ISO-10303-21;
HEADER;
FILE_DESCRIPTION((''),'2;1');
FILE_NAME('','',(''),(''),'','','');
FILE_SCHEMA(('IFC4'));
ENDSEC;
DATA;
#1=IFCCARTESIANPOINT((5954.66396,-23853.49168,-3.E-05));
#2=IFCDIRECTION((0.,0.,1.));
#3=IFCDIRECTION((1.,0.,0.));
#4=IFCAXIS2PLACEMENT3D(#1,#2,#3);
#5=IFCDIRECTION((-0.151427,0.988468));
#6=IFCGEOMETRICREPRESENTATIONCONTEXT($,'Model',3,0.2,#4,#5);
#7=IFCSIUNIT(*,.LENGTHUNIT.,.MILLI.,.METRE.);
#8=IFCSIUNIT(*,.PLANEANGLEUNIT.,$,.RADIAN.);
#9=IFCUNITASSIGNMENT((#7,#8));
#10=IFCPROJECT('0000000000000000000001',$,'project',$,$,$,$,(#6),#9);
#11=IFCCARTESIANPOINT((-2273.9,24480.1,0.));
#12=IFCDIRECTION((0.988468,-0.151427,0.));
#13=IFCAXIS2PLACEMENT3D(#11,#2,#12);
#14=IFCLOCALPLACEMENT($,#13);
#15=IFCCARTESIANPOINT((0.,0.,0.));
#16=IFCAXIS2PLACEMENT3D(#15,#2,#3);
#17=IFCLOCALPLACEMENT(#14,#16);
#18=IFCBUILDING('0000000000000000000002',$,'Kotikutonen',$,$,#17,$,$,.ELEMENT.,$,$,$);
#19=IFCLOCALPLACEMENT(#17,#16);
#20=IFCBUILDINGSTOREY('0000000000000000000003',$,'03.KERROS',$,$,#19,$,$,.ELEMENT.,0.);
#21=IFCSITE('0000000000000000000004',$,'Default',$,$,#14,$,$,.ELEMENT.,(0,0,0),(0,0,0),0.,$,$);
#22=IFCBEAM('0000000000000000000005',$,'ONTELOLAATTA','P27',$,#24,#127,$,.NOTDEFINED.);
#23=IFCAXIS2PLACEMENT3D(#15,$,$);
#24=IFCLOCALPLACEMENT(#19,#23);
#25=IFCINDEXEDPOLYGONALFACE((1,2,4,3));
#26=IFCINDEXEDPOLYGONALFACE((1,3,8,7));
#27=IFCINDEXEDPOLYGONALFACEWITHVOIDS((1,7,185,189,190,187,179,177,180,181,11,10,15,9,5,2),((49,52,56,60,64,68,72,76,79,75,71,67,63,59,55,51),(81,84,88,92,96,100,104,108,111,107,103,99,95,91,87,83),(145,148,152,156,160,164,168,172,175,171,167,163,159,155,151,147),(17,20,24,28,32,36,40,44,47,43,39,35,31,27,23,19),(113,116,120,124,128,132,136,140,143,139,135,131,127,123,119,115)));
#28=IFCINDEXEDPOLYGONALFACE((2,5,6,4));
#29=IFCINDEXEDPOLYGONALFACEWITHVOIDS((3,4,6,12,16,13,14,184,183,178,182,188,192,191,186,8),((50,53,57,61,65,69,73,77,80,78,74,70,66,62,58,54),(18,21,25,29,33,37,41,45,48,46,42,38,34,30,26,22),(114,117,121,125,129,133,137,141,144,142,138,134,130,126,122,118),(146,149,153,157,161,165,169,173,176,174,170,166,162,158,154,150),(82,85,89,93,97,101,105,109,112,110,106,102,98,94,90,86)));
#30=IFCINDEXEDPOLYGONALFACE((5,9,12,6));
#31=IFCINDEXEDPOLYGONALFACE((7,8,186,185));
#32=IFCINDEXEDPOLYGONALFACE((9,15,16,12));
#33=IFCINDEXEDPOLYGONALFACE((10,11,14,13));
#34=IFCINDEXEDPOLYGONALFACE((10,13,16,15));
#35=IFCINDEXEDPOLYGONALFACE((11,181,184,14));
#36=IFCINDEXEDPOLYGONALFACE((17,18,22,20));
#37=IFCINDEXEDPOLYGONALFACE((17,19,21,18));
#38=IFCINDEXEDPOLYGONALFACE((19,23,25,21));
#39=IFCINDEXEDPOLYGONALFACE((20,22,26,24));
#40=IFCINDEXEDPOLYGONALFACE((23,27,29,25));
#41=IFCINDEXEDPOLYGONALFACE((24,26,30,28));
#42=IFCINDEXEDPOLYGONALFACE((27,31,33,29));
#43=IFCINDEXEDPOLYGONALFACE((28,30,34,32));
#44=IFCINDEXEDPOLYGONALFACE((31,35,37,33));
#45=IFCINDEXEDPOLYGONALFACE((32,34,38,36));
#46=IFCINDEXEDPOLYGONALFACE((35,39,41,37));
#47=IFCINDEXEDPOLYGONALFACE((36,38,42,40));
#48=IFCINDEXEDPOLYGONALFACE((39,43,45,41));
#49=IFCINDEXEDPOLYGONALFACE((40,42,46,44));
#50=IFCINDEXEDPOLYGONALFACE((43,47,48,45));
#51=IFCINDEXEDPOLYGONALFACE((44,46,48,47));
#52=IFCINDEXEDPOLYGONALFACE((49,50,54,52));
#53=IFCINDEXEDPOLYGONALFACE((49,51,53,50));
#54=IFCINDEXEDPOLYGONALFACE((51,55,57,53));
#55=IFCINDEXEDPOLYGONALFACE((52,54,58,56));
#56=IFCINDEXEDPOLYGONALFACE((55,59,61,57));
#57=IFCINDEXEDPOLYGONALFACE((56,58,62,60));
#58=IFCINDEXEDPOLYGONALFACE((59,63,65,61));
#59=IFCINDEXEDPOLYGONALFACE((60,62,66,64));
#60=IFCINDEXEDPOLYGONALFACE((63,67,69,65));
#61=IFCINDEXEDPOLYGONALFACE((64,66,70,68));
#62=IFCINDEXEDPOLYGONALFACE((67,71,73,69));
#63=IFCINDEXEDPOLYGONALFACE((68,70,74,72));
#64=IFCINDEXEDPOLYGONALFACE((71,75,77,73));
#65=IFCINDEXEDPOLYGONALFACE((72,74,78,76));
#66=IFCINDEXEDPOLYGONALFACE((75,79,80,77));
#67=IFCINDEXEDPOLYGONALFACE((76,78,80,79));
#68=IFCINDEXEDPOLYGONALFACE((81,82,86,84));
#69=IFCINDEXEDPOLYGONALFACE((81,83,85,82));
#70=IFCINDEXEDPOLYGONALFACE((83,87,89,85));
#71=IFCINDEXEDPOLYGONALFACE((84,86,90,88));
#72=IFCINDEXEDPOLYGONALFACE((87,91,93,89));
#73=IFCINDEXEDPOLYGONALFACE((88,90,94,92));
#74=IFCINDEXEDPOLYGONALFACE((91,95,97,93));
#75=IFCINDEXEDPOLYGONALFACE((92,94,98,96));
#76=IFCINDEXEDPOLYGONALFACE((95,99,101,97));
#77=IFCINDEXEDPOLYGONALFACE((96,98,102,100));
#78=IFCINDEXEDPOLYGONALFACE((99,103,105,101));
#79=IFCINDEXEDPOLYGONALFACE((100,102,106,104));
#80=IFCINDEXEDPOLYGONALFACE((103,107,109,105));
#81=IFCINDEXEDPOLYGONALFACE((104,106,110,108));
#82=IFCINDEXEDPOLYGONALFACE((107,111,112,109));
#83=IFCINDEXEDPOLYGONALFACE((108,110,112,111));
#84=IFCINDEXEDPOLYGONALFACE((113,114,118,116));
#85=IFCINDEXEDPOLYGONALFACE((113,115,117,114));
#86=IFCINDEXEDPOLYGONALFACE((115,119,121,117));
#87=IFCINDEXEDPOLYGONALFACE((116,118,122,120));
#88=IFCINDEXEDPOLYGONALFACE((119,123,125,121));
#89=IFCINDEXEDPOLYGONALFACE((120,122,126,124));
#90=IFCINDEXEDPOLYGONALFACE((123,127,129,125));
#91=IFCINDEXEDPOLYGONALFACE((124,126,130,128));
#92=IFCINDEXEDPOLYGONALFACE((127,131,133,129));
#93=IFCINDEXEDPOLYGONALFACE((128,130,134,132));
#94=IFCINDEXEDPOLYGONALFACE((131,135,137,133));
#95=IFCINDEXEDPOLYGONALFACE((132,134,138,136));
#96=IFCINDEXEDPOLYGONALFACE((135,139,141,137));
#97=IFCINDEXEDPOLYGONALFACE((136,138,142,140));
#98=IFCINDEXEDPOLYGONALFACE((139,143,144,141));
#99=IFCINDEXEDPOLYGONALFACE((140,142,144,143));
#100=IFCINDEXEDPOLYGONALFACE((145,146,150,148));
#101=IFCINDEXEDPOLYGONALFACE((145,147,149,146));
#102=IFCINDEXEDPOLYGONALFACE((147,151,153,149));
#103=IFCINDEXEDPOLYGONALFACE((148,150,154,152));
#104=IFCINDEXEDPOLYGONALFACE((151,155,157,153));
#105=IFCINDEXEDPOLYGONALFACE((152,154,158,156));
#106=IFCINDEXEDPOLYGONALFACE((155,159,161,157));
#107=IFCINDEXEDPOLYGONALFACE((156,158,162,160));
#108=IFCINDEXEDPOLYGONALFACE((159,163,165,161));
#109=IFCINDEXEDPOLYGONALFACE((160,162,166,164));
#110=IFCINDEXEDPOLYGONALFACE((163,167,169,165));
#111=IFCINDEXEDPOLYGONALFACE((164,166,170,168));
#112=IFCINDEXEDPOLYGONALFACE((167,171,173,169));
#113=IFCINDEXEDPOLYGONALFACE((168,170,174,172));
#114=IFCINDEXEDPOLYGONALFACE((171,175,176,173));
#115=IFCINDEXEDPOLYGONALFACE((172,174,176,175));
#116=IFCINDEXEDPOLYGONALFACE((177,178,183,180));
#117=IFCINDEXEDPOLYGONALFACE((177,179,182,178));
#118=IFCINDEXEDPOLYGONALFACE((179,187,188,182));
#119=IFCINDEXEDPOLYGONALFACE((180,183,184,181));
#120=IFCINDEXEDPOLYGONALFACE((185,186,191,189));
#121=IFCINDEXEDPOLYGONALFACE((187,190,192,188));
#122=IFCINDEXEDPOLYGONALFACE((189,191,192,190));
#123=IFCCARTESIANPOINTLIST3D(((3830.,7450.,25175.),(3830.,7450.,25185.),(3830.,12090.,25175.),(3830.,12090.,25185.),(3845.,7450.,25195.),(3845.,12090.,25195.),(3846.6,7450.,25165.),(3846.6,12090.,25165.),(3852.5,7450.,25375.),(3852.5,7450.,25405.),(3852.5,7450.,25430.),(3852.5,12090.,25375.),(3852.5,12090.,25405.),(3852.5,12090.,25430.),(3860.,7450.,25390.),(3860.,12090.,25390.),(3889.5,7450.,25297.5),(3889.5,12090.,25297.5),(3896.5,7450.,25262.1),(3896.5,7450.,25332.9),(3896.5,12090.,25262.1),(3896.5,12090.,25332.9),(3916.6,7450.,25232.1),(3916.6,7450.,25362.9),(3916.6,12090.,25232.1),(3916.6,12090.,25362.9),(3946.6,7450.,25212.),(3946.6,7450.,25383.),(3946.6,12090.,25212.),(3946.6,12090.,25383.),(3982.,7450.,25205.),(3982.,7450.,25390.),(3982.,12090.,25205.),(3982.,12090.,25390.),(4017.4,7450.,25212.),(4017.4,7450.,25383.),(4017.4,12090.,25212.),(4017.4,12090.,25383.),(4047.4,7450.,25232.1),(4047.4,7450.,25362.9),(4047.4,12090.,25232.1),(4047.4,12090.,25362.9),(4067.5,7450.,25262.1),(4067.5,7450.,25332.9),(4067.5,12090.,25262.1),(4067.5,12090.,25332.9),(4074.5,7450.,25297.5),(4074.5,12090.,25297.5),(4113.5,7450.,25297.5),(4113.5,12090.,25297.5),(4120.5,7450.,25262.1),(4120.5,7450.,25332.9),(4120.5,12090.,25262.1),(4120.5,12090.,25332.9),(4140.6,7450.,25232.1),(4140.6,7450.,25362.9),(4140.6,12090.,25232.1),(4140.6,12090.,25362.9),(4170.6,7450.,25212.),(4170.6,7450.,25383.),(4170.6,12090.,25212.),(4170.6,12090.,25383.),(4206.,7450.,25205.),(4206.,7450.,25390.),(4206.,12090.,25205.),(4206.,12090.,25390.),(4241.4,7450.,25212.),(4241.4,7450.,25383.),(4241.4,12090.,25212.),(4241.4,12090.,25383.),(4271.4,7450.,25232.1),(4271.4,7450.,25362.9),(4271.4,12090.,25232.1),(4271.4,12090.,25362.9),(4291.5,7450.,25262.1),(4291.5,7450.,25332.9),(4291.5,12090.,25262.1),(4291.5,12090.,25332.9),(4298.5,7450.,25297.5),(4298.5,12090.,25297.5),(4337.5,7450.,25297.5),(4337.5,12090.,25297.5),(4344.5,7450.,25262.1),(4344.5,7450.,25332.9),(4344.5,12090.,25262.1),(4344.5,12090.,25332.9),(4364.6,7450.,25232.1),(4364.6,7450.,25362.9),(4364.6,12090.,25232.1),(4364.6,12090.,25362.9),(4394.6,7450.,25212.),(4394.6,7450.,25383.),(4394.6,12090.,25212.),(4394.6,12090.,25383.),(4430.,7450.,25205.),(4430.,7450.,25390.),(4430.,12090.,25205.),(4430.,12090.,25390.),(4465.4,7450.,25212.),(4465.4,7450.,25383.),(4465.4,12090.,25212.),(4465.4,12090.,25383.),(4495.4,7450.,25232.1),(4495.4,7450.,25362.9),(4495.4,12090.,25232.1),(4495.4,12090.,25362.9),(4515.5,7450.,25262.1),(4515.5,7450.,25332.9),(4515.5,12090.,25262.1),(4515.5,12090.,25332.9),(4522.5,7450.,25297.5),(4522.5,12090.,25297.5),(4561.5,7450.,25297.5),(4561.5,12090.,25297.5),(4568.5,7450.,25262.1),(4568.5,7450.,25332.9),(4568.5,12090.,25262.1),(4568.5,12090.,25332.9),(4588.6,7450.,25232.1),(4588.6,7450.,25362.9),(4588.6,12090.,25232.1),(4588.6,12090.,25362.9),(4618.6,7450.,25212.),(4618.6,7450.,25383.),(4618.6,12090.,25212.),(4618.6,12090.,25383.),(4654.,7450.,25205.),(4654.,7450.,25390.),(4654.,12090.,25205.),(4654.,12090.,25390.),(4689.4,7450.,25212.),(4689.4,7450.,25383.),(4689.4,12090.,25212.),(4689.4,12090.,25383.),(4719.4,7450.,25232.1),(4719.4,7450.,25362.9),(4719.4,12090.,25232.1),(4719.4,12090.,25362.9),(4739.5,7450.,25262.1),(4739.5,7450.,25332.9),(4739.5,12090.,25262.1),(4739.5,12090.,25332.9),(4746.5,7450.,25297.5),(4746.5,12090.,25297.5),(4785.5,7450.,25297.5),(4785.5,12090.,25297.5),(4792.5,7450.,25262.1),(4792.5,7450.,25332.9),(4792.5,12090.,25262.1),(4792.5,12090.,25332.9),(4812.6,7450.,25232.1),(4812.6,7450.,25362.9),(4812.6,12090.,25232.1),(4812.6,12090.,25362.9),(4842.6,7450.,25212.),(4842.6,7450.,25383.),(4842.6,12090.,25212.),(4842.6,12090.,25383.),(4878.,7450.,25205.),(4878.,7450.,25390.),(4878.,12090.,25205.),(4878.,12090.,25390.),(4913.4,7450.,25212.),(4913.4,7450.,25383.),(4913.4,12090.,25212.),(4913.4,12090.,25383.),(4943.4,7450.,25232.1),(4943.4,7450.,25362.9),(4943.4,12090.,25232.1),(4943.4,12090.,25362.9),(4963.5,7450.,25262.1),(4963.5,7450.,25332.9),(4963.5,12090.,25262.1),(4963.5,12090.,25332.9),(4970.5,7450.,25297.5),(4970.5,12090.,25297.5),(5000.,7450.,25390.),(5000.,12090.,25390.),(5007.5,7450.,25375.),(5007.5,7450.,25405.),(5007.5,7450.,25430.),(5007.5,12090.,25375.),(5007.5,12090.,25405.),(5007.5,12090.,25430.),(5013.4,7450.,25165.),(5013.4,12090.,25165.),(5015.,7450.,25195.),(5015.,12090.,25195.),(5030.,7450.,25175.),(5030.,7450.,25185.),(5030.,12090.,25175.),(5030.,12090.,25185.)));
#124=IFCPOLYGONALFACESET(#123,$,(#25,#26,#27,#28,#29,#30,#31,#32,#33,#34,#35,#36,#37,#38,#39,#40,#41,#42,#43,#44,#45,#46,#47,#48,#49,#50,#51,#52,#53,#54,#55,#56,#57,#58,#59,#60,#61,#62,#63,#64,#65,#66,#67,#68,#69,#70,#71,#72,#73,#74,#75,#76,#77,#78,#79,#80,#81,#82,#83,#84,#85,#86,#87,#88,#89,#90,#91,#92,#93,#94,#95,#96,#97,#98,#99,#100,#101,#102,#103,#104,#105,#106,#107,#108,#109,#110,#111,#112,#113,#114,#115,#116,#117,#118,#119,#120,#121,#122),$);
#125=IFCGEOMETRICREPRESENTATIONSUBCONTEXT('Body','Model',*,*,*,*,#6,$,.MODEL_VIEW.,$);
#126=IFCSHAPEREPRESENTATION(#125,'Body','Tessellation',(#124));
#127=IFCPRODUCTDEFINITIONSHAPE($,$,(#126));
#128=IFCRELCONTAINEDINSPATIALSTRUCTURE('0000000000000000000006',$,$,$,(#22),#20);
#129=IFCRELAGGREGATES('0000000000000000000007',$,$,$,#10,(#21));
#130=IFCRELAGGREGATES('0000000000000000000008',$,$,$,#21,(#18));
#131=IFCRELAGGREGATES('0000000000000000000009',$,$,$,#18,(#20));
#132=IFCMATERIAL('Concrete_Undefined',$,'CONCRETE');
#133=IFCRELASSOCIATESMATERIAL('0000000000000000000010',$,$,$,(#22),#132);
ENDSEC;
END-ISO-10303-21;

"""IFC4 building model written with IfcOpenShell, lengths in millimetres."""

from ifc_helpers import new_model, si_unit, direction, frame, origin_with_axes, place, context, subcontext, project, spatial, line, indexed_curve, outline, extrude, material, element, save


model = new_model("IFC4")

# Units and contexts
model_context = context("Model", 3, precision=0.2, world=frame((5954.66396, -23853.49168, -3e-05), z_axis=(0.0, 0.0, 1.0), x_axis=(1.0, 0.0, 0.0)), true_north=direction((-0.151427, 0.988468)))
body_context = subcontext(model_context, "Body", "Model", "MODEL_VIEW")
ifc_project = project(units=[si_unit("LENGTHUNIT", "METRE", prefix="MILLI"), si_unit("PLANEANGLEUNIT", "RADIAN")], contexts=[model_context])

# Site, building, storey
site_placement = place(None, frame((-2273.9, 24480.1, 0.0), z_axis=(0.0, 0.0, 1.0), x_axis=(0.988468, -0.151427, 0.0)))
site = spatial("IfcSite", under=ifc_project, at=site_placement, Name="Default", CompositionType="ELEMENT", RefLatitude=(0, 0, 0), RefLongitude=(0, 0, 0), RefElevation=0.0)
building_placement = place(site_placement, origin_with_axes())
building = spatial("IfcBuilding", under=site, at=building_placement, Name="Kotikutonen", CompositionType="ELEMENT")
storey_placement = place(building_placement, origin_with_axes())
storey = spatial("IfcBuildingStorey", under=building, at=storey_placement, Name="03.KERROS", CompositionType="ELEMENT", Elevation=0.0)

# Shared definitions
ifc_material_1 = material(Name="Concrete_Undefined", Category="CONCRETE")

# Beam
beam_1_placement = place(storey_placement, frame((4430.0, 12090.0, 25297.5), z_axis=(-1.0, 0.0, 0.0), x_axis=(0.0, -1.0, 0.0)))
element("IfcBeam", 1, at=beam_1_placement, inside=storey, material=ifc_material_1, Name="ONTELOLAATTA", Description="P27", PredefinedType="NOTDEFINED", context=body_context, shape_type="SolidModel", body=[
    extrude(outline(indexed_curve([(-600.0, -122.5), (-583.4, -132.5), (583.4, -132.5), (600.0, -122.5), (600.0, -112.5), (585.0, -102.5), (577.5, 77.5), (570.0, 92.5), (577.5, 107.5), (577.5, 132.5), (-577.5, 132.5), (-577.5, 107.5), (-570.0, 92.5), (-577.5, 77.5), (-585.0, -102.5), (-600.0, -112.5)], segments=[line(1, 2, 3, 4, 5, 6, 7, 8, 9, 10, 11, 12, 13, 14, 15, 16, 1)]), holes=[indexed_curve([(-448.0, -92.5), (-483.4, -85.5), (-513.4, -65.4), (-533.5, -35.4), (-540.5, 0.0), (-533.5, 35.4), (-513.4, 65.4), (-483.4, 85.5), (-448.0, 92.5), (-412.6, 85.5), (-382.6, 65.4), (-362.5, 35.4), (-355.5, 0.0), (-362.5, -35.4), (-382.6, -65.4), (-412.6, -85.5)], segments=[line(1, 2, 3, 4, 5, 6, 7, 8, 9, 10, 11, 12, 13, 14, 15, 16, 1)]), indexed_curve([(-224.0, -92.5), (-259.4, -85.5), (-289.4, -65.4), (-309.5, -35.4), (-316.5, 0.0), (-309.5, 35.4), (-289.4, 65.4), (-259.4, 85.5), (-224.0, 92.5), (-188.6, 85.5), (-158.6, 65.4), (-138.5, 35.4), (-131.5, 0.0), (-138.5, -35.4), (-158.6, -65.4), (-188.6, -85.5)], segments=[line(1, 2, 3, 4, 5, 6, 7, 8, 9, 10, 11, 12, 13, 14, 15, 16, 1)]), indexed_curve([(0.0, -92.5), (-35.4, -85.5), (-65.4, -65.4), (-85.5, -35.4), (-92.5, 0.0), (-85.5, 35.4), (-65.4, 65.4), (-35.4, 85.5), (0.0, 92.5), (35.4, 85.5), (65.4, 65.4), (85.5, 35.4), (92.5, 0.0), (85.5, -35.4), (65.4, -65.4), (35.4, -85.5)], segments=[line(1, 2, 3, 4, 5, 6, 7, 8, 9, 10, 11, 12, 13, 14, 15, 16, 1)]), indexed_curve([(224.0, -92.5), (188.6, -85.5), (158.6, -65.4), (138.5, -35.4), (131.5, 0.0), (138.5, 35.4), (158.6, 65.4), (188.6, 85.5), (224.0, 92.5), (259.4, 85.5), (289.4, 65.4), (309.5, 35.4), (316.5, 0.0), (309.5, -35.4), (289.4, -65.4), (259.4, -85.5)], segments=[line(1, 2, 3, 4, 5, 6, 7, 8, 9, 10, 11, 12, 13, 14, 15, 16, 1)]), indexed_curve([(448.0, -92.5), (412.6, -85.5), (382.6, -65.4), (362.5, -35.4), (355.5, 0.0), (362.5, 35.4), (382.6, 65.4), (412.6, 85.5), (448.0, 92.5), (483.4, 85.5), (513.4, 65.4), (533.5, 35.4), (540.5, 0.0), (533.5, -35.4), (513.4, -65.4), (483.4, -85.5)], segments=[line(1, 2, 3, 4, 5, 6, 7, 8, 9, 10, 11, 12, 13, 14, 15, 16, 1)])]), frame((0.0, 0.0, 0.0), z_axis=(-1.0, 0.0, 0.0), x_axis=(0.0, 0.0, 1.0)), (0.0, 0.0, -1.0), 4640.0),
])

save(model, "model.ifc")
